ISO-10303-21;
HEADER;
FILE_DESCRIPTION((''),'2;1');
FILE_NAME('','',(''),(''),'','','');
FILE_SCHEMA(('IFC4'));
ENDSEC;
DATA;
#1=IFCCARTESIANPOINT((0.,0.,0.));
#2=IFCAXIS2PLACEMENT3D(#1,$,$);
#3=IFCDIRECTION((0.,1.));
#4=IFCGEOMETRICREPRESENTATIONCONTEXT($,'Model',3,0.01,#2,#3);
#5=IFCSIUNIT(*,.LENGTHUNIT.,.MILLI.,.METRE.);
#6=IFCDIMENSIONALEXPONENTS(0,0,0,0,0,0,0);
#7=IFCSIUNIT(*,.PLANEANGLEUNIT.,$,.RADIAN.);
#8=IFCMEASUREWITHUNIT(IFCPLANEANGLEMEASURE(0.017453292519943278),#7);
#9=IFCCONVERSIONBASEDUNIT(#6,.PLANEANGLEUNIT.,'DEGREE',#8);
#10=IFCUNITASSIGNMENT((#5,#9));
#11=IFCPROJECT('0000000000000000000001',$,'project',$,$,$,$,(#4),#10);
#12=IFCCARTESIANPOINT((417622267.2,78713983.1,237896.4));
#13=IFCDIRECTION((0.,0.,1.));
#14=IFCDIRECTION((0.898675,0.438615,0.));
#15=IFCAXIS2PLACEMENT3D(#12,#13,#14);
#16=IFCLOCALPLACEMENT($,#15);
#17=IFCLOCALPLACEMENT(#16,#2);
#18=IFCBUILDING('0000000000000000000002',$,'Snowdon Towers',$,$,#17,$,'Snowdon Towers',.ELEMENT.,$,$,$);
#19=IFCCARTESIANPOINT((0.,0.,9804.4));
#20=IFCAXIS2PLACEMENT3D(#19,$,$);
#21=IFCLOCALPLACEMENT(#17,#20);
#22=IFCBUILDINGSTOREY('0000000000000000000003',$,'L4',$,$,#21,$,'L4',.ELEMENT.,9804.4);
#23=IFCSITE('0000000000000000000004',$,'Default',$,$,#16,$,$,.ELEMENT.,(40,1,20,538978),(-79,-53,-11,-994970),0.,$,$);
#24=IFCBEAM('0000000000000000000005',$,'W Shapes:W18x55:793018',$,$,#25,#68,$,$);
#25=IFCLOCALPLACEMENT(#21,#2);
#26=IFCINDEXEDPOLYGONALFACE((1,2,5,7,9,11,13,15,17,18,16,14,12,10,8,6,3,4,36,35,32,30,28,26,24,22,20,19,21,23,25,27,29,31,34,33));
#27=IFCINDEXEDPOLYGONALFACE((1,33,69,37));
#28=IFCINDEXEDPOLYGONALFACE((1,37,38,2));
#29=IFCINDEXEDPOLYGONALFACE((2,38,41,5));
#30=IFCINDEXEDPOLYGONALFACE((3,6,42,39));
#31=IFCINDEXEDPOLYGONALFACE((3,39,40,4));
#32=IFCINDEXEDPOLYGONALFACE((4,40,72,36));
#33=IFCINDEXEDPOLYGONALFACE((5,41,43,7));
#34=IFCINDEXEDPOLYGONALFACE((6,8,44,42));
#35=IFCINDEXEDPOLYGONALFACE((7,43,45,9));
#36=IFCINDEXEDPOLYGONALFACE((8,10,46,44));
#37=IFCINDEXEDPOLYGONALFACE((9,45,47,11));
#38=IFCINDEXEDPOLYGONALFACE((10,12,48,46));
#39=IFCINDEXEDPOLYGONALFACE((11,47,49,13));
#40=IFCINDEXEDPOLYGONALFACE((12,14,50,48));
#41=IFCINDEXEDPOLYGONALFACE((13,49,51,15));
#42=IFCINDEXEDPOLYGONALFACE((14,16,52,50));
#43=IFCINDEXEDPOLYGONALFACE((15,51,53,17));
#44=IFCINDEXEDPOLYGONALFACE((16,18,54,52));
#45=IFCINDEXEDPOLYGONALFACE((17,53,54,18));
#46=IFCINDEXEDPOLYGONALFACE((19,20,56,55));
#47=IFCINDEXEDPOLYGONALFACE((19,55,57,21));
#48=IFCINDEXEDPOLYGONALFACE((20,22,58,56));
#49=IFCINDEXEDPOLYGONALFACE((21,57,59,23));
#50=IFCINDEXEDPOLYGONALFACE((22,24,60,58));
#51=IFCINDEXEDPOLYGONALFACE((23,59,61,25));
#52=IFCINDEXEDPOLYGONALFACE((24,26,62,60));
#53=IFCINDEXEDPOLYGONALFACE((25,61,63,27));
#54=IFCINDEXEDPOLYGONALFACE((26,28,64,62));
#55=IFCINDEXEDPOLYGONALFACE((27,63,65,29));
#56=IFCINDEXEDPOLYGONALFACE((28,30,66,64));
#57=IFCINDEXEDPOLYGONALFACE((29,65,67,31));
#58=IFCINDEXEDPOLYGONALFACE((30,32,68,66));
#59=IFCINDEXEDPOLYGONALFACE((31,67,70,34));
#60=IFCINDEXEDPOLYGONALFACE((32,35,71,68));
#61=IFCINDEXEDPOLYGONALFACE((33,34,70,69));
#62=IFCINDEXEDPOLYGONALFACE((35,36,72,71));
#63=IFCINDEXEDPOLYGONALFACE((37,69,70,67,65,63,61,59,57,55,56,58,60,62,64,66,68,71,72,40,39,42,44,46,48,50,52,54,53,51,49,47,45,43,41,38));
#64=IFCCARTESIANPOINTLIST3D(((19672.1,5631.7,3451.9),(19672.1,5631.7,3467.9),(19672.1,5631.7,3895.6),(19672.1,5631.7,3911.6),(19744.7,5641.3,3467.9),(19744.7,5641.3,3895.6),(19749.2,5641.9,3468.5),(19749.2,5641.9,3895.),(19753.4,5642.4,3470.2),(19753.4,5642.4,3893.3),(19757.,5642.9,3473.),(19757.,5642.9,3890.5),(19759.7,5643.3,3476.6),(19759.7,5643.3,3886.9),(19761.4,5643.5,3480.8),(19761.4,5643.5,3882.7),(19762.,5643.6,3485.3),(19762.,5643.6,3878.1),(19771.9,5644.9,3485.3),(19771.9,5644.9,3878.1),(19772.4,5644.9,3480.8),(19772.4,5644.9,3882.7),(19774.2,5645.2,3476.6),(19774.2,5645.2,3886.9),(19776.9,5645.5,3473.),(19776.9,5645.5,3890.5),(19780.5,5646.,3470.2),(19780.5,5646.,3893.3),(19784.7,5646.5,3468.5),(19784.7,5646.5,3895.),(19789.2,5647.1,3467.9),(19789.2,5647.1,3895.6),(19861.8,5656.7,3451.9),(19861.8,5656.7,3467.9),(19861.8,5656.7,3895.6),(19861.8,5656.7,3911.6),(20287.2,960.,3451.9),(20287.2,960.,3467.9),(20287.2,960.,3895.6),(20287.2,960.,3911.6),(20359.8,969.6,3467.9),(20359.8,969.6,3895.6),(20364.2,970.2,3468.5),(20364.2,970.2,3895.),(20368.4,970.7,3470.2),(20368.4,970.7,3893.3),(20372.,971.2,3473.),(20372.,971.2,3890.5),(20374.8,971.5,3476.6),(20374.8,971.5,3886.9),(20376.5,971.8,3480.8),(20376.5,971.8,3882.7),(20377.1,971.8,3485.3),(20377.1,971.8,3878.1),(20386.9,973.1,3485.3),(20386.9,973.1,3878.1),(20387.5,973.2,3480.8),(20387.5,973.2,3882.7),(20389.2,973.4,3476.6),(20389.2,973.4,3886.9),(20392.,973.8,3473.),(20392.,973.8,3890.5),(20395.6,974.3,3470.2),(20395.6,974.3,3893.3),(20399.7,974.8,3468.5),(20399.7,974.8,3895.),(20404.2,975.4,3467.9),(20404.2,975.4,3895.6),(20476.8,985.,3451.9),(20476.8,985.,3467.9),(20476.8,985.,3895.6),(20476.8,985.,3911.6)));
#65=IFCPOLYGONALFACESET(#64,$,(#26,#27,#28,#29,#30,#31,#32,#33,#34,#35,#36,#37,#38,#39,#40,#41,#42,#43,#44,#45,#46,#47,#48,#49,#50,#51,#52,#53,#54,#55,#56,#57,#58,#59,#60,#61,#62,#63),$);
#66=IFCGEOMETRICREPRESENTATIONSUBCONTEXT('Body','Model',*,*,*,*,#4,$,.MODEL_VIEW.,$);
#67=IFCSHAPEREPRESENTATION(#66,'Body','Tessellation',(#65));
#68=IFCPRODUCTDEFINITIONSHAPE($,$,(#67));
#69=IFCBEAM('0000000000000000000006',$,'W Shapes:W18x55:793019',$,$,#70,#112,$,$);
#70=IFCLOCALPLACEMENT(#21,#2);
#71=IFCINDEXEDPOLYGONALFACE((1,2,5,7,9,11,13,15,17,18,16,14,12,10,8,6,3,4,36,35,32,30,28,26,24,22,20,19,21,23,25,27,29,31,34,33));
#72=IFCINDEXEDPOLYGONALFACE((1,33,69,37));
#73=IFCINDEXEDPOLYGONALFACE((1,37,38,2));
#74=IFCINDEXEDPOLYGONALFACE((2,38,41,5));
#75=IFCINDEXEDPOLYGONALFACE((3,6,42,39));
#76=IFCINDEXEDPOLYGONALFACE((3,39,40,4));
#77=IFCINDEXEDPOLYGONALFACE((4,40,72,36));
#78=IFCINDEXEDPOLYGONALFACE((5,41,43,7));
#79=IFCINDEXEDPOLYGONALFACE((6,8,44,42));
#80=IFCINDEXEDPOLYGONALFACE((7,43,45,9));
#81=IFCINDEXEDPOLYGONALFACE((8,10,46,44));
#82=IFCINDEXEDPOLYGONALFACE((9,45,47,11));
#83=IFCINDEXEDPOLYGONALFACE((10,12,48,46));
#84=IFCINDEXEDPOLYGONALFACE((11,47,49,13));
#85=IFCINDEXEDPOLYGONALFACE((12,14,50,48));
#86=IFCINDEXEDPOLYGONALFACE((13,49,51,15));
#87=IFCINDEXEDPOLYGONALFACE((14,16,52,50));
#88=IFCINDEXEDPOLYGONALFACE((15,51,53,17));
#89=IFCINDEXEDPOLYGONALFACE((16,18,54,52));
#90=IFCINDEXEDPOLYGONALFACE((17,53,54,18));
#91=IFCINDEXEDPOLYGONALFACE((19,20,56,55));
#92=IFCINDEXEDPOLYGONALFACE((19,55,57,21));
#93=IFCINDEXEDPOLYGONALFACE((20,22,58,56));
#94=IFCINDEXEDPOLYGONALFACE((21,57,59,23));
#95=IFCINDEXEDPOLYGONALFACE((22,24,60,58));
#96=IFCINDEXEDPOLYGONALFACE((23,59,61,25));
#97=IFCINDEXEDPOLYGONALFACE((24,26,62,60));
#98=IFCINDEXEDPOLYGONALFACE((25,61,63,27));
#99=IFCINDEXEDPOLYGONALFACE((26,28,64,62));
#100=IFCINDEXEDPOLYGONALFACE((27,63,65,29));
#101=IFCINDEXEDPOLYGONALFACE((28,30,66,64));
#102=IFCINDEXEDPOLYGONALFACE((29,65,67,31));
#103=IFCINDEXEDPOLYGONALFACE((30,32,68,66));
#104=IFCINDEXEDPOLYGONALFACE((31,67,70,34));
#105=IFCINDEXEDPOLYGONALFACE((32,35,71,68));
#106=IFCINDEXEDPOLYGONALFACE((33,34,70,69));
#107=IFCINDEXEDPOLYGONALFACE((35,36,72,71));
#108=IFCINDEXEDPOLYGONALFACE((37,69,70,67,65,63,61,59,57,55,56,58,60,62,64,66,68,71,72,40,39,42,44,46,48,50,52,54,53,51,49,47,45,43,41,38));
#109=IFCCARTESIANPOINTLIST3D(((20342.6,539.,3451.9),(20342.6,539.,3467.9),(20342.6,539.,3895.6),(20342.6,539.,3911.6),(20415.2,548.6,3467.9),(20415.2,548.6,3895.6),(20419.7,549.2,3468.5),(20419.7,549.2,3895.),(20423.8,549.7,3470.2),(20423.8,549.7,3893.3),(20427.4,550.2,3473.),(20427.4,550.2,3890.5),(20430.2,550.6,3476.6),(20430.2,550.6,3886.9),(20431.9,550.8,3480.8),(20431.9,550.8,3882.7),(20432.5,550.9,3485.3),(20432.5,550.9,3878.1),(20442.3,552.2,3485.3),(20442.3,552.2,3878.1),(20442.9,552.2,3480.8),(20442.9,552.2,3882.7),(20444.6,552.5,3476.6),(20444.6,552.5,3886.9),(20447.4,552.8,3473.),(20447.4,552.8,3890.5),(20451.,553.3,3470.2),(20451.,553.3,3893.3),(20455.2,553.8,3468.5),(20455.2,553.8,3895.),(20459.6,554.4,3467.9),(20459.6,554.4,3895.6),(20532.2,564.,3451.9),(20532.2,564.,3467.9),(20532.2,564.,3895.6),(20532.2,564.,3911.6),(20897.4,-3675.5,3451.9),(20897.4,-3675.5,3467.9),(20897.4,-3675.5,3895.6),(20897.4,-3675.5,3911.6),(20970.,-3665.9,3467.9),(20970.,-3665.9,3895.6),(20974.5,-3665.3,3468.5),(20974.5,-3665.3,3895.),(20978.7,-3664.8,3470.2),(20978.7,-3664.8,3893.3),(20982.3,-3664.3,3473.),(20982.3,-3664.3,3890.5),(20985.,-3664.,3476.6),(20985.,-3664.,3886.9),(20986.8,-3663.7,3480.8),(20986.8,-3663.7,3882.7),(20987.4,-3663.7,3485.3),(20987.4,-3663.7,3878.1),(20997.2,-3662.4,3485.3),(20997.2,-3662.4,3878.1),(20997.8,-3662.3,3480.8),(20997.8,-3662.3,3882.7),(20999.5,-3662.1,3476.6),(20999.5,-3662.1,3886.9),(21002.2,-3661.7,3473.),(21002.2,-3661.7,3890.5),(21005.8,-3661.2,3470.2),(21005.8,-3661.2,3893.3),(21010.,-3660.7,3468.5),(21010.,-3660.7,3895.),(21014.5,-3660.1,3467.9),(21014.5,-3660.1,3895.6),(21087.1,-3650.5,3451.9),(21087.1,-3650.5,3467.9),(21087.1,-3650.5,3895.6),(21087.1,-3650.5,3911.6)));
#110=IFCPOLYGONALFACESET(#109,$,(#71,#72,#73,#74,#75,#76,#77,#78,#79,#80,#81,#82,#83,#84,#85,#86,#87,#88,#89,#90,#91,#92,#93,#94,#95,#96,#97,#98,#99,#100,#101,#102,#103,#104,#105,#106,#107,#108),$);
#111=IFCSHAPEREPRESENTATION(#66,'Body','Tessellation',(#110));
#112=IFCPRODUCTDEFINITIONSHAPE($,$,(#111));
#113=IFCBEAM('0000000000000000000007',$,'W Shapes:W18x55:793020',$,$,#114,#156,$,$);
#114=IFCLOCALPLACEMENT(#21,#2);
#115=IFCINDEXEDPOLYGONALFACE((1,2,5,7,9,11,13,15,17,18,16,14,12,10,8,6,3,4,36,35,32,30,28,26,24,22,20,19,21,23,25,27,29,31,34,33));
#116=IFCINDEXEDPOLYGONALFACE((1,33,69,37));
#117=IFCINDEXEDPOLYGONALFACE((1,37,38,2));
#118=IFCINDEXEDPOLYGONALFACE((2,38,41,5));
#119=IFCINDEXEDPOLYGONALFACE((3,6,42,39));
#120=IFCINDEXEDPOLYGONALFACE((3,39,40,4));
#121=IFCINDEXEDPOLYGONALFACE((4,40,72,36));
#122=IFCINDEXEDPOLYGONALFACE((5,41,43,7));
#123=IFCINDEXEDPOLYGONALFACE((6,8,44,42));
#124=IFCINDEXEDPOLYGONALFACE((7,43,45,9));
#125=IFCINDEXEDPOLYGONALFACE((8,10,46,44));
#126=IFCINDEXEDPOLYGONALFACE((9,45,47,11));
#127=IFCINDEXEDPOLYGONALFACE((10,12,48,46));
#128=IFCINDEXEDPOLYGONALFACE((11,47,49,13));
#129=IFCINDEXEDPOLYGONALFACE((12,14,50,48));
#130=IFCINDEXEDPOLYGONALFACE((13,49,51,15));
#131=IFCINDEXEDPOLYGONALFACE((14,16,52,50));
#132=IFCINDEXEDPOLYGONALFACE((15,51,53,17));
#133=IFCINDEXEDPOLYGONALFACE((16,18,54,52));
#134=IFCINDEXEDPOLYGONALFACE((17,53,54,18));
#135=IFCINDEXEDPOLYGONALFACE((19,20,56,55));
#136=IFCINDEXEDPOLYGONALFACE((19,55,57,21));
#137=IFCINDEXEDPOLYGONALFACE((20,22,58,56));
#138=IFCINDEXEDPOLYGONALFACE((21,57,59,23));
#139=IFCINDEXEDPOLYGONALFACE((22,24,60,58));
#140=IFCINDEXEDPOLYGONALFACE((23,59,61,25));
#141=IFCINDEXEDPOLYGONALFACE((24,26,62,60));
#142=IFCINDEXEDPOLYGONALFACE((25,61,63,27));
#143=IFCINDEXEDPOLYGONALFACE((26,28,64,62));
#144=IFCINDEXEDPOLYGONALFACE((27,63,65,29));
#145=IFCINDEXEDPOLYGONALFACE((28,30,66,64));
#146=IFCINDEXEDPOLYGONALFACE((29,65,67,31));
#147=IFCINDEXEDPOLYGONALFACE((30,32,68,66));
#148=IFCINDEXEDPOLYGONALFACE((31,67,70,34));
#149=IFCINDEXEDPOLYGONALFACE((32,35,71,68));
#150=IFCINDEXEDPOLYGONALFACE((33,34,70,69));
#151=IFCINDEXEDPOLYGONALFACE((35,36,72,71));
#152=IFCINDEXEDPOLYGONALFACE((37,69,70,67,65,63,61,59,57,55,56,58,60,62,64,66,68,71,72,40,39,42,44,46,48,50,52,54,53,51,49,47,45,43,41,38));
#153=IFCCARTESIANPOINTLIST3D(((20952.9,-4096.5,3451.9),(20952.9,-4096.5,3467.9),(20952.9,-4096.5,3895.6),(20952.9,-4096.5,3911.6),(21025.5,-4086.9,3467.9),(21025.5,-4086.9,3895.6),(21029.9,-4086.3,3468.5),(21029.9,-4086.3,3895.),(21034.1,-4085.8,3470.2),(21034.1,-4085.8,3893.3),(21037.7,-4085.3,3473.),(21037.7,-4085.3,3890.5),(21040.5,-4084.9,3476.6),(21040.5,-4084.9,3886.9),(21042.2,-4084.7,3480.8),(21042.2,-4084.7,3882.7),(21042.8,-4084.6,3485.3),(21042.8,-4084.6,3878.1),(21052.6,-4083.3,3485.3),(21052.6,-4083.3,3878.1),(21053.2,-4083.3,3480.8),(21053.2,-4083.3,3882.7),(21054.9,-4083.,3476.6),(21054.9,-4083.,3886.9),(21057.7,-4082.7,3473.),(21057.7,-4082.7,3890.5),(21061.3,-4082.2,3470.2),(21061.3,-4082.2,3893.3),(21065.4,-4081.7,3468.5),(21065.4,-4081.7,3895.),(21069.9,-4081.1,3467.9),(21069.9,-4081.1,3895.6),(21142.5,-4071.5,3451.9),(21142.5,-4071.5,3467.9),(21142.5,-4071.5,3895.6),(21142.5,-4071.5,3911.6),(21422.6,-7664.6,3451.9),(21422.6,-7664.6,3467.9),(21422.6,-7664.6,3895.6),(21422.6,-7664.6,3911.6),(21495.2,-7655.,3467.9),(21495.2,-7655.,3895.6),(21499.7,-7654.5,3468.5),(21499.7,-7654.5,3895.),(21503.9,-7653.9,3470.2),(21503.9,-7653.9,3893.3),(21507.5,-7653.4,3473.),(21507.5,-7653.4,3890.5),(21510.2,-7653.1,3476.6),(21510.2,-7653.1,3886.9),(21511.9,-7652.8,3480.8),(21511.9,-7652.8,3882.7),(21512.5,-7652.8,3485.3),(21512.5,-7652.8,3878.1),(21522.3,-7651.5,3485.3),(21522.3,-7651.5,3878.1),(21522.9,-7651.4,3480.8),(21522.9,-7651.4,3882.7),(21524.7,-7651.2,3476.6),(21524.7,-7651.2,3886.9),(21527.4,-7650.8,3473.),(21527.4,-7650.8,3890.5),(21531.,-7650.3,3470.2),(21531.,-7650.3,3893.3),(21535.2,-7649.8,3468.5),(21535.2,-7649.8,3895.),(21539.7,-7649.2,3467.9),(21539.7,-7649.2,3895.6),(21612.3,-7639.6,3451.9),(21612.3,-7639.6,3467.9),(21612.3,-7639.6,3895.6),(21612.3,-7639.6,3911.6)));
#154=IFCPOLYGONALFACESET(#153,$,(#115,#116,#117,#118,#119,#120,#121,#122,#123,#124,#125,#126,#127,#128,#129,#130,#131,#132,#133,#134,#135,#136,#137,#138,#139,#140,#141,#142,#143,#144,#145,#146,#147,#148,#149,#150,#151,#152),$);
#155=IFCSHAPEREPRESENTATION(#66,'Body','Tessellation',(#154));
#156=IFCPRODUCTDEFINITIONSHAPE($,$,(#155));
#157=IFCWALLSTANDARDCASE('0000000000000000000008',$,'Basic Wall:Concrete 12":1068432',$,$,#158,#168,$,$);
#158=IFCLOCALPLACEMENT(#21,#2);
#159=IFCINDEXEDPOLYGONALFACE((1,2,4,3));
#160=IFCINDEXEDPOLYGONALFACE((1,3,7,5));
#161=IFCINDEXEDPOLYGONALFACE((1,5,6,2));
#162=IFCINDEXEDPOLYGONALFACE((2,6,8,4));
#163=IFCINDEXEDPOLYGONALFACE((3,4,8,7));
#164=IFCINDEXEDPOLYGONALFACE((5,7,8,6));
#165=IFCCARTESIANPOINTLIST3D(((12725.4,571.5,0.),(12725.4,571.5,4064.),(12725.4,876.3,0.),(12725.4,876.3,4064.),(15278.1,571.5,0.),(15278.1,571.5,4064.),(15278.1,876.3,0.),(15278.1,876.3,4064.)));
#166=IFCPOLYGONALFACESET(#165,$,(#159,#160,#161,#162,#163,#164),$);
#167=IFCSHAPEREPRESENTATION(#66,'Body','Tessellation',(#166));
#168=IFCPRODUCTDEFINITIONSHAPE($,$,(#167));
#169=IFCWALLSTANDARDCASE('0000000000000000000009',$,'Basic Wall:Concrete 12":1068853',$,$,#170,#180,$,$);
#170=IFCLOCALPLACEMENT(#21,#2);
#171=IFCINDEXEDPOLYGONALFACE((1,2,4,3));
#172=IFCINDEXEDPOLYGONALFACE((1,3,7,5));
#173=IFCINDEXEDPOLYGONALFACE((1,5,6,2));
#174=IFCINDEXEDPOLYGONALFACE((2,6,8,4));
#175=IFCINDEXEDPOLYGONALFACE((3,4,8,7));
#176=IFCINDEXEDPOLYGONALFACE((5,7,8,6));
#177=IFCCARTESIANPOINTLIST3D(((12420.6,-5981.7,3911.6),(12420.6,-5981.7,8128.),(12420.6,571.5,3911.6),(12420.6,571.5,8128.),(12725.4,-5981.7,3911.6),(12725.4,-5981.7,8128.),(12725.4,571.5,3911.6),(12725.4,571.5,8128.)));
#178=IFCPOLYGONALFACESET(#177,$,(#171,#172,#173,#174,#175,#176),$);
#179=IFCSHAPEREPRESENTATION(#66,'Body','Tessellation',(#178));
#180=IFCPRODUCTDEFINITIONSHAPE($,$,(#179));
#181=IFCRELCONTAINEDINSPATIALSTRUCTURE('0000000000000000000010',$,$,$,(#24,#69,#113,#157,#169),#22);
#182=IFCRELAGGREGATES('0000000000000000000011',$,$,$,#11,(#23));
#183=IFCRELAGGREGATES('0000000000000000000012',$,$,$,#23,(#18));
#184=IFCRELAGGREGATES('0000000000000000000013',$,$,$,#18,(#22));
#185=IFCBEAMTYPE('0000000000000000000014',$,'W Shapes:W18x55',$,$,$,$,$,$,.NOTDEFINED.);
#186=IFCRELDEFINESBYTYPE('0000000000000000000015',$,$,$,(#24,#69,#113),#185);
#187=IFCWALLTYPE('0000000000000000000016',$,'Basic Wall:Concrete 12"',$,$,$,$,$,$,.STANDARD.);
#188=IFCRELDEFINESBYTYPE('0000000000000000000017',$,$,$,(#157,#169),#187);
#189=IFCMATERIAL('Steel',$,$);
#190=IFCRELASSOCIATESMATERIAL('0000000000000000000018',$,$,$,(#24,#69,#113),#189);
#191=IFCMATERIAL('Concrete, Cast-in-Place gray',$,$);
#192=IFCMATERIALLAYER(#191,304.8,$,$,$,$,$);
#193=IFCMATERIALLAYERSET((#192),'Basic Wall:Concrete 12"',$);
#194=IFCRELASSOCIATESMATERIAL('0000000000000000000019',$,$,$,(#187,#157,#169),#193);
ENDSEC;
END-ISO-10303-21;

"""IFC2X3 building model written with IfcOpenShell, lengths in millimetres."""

from ifc_helpers import new_model, entity, si_unit, converted_unit, direction, frame, frame_2d, origin, place, context, subcontext, project, spatial, rectangle, i_section, extrude, material, layer, layer_set, layer_usage, type_object, element, save


model = new_model("IFC2X3")

# Units and contexts
model_context = context("Model", 3, precision=0.01, world=origin(), true_north=direction((0.0, 1.0)))
body_context = subcontext(model_context, "Body", "Model", "MODEL_VIEW")
ifc_project = project(units=[si_unit("LENGTHUNIT", "METRE", prefix="MILLI"), converted_unit("PLANEANGLEUNIT", "DEGREE", entity("IfcPlaneAngleMeasure", 0.017453292519943278), si_unit("PLANEANGLEUNIT", "RADIAN"), dimensions=[0, 0, 0, 0, 0, 0, 0])], contexts=[model_context])

# Site, building, storey
site_placement = place(None, frame((417622267.2, 78713983.1, 237896.4), z_axis=(0.0, 0.0, 1.0), x_axis=(0.898675, 0.438615, 0.0)))
site = spatial("IfcSite", under=ifc_project, at=site_placement, Name="Default", CompositionType="ELEMENT", RefLatitude=(40, 1, 20, 538978), RefLongitude=(-79, -53, -11, -994970), RefElevation=0.0)
building_placement = place(site_placement, origin())
building = spatial("IfcBuilding", under=site, at=building_placement, Name="Snowdon Towers", LongName="Snowdon Towers", CompositionType="ELEMENT")
storey_placement = place(building_placement, frame((0.0, 0.0, 9804.4)))
storey = spatial("IfcBuildingStorey", under=building, at=storey_placement, Name="L4", LongName="L4", CompositionType="ELEMENT", Elevation=9804.4)

# Shared definitions
ifc_material_1 = material(Name="Steel")

# Beams
beam_type = type_object("IfcBeamType", Name="W Shapes:W18x55", PredefinedType="NOTDEFINED")
beam_1_placement = place(storey_placement, frame((19739.2, 5854.7, 3911.6), z_axis=(0.0, 0.0, 1.0), x_axis=(0.130526, -0.991445, 0.0)))
element("IfcBeam", 1, at=beam_1_placement, inside=storey, type_object=beam_type, material=ifc_material_1, Name="W Shapes:W18x55:793018", context=body_context, shape_type="SweptSolid", body=[
    extrude(i_section(OverallWidth=191.3, OverallDepth=459.7, WebThickness=9.9, FlangeThickness=16.0, FilletRadius=17.5, at=frame_2d((0.0, 0.0), x_axis=(0.0, 1.0))), frame((212.3, 0.0, -229.9), z_axis=(1.0, 0.0, 0.0), x_axis=(0.0, 0.0, -1.0)), (0.0, 0.0, 1.0), 4712.0),
])
beam_2_placement = place(storey_placement, frame((20409.7, 762.0, 3911.6), z_axis=(0.0, 0.0, 1.0), x_axis=(0.130526, -0.991445, 0.0)))
element("IfcBeam", 2, at=beam_2_placement, inside=storey, type_object=beam_type, material=ifc_material_1, Name="W Shapes:W18x55:793019", context=body_context, shape_type="SweptSolid", body=[
    extrude(i_section(OverallWidth=191.3, OverallDepth=459.7, WebThickness=9.9, FlangeThickness=16.0, FilletRadius=17.5, at=frame_2d((0.0, 0.0), x_axis=(0.0, 1.0))), frame((212.3, 0.0, -229.9), z_axis=(1.0, 0.0, 0.0), x_axis=(0.0, 0.0, -1.0)), (0.0, 0.0, 1.0), 4250.9),
])
beam_3_placement = place(storey_placement, frame((21020.0, -3873.5, 3911.6), z_axis=(0.0, 0.0, 1.0), x_axis=(0.130526, -0.991445, 0.0)))
element("IfcBeam", 3, at=beam_3_placement, inside=storey, type_object=beam_type, material=ifc_material_1, Name="W Shapes:W18x55:793020", context=body_context, shape_type="SweptSolid", body=[
    extrude(i_section(OverallWidth=191.3, OverallDepth=459.7, WebThickness=9.9, FlangeThickness=16.0, FilletRadius=17.5, at=frame_2d((0.0, 0.0), x_axis=(0.0, 1.0))), frame((212.3, 0.0, -229.9), z_axis=(1.0, 0.0, 0.0), x_axis=(0.0, 0.0, -1.0)), (0.0, 0.0, 1.0), 3598.9),
])

# Walls
ifc_material_2 = material(Name="Concrete, Cast-in-Place gray")
ifc_layer = layer(ifc_material_2, 304.8)
ifc_layer_set = layer_set([ifc_layer], Name="Basic Wall:Concrete 12\"")
ifc_layer_usage_1 = layer_usage(ifc_layer_set, "AXIS2", "POSITIVE", -152.4)
wall_type = type_object("IfcWallType", Name="Basic Wall:Concrete 12\"", PredefinedType="STANDARD", material=ifc_layer_set)
wall_1_placement = place(storey_placement, frame((15278.1, 723.9, 0.0), z_axis=(0.0, 0.0, 1.0), x_axis=(-1.0, 0.0, 0.0)))
element("IfcWallStandardCase", 4, at=wall_1_placement, inside=storey, type_object=wall_type, material=ifc_layer_usage_1, Name="Basic Wall:Concrete 12\":1068432", context=body_context, shape_type="SweptSolid", body=[
    extrude(rectangle(XDim=2552.7, YDim=304.8, at=frame_2d((1276.3, 0.0), x_axis=(-1.0, 0.0))), origin(), (0.0, 0.0, 1.0), 4064.0),
])
ifc_layer_usage_2 = layer_usage(ifc_layer_set, "AXIS2", "POSITIVE", -152.4)
wall_2_placement = place(storey_placement, frame((12573.0, 571.5, 3911.6), z_axis=(0.0, 0.0, 1.0), x_axis=(0.0, -1.0, 0.0)))
element("IfcWallStandardCase", 5, at=wall_2_placement, inside=storey, type_object=wall_type, material=ifc_layer_usage_2, Name="Basic Wall:Concrete 12\":1068853", context=body_context, shape_type="SweptSolid", body=[
    extrude(rectangle(XDim=6553.2, YDim=304.8, at=frame_2d((3276.6, 0.0), x_axis=(-1.0, 0.0))), origin(), (0.0, 0.0, 1.0), 4216.4),
])

save(model, "model.ifc")
